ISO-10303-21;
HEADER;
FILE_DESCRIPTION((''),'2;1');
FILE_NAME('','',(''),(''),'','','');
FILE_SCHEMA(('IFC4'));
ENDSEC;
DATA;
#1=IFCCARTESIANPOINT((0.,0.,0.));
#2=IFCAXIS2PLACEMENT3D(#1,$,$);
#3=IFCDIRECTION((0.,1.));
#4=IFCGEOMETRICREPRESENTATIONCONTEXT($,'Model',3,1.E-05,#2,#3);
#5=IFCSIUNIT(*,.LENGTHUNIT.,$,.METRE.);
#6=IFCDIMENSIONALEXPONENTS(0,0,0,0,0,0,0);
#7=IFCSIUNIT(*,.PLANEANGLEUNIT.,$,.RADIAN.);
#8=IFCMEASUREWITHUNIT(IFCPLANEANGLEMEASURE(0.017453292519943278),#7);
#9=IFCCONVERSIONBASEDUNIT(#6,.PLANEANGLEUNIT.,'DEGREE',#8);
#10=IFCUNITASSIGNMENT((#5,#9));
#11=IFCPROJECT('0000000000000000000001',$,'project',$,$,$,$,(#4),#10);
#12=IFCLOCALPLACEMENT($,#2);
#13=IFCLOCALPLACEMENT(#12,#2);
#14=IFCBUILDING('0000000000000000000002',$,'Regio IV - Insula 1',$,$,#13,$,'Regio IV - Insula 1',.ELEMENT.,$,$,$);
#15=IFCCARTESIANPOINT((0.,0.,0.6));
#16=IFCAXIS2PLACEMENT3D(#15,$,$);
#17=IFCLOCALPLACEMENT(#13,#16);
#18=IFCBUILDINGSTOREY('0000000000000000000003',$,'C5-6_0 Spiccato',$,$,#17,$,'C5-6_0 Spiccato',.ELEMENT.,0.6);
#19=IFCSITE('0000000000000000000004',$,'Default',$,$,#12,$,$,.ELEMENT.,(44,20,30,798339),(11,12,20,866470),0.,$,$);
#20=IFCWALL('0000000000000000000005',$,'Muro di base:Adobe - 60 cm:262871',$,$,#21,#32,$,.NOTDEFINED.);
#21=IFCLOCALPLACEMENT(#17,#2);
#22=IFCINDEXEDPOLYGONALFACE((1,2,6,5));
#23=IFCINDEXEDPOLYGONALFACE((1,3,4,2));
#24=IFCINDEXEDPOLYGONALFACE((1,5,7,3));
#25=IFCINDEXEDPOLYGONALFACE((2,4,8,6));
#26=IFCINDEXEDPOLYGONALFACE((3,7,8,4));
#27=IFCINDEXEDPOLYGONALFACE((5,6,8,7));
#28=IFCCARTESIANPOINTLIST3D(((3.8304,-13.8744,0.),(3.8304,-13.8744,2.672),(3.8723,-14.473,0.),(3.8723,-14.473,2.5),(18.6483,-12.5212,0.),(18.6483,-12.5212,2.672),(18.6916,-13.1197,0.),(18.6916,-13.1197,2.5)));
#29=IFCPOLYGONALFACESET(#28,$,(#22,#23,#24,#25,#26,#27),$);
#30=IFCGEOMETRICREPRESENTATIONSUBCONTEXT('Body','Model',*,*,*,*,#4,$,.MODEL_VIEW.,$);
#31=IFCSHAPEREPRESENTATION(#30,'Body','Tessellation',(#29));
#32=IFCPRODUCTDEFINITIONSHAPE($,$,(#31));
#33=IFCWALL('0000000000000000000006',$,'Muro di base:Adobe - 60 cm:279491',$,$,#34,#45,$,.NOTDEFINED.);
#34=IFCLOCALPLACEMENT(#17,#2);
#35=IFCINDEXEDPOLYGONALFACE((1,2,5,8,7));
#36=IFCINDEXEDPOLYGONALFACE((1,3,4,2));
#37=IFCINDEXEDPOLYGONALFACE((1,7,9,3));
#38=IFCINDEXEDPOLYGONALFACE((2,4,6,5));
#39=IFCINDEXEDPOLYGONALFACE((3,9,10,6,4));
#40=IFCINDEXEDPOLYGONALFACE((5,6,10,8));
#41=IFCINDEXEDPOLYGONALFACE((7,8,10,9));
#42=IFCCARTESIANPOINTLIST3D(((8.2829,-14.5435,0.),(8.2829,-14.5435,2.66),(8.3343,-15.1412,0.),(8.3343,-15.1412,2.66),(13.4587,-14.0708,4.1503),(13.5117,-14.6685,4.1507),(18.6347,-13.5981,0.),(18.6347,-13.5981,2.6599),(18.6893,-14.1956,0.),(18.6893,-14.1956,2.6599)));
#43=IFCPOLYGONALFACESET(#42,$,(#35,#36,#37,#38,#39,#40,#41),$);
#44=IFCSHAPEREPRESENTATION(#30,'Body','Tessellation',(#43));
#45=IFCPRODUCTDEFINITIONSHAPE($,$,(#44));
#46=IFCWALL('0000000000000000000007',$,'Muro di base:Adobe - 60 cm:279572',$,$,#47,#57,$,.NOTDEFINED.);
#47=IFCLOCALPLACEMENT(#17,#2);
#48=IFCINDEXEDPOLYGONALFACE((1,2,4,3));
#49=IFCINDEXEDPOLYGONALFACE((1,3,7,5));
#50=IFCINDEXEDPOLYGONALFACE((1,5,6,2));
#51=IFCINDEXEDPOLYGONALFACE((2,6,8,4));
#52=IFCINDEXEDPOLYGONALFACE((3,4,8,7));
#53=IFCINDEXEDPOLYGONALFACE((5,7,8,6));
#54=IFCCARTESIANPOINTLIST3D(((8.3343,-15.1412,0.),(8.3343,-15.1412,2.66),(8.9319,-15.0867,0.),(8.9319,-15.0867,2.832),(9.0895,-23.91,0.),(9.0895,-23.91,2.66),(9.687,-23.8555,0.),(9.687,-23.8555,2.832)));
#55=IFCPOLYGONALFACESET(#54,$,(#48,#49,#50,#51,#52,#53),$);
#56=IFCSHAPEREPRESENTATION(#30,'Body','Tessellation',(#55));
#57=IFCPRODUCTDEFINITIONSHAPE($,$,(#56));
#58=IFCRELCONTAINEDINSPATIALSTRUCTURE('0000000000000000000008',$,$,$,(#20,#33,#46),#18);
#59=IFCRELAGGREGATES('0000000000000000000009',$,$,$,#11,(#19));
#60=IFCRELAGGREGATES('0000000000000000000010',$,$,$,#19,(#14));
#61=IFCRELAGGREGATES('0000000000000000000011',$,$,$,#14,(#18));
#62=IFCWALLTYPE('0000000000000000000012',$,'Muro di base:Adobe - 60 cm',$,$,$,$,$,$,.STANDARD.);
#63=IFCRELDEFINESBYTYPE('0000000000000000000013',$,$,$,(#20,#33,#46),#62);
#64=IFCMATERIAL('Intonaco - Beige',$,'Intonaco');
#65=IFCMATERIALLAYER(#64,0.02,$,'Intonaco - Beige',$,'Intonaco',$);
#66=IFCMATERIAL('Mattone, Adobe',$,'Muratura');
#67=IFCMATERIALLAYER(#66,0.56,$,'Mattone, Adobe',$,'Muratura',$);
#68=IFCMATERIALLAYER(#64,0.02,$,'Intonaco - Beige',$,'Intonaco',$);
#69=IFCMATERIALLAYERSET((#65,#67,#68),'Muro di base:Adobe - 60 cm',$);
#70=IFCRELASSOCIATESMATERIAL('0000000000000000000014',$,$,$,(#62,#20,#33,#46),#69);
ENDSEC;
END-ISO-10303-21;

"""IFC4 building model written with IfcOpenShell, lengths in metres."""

from ifc_helpers import new_model, entity, si_unit, converted_unit, direction, frame, origin, place, context, subcontext, project, spatial, polyline, outline, extrude, clip, bounded_halfspace, material, layer, layer_set, layer_usage, type_object, element, save


model = new_model("IFC4")

# Units and contexts
model_context = context("Model", 3, precision=1e-05, world=origin(), true_north=direction((0.0, 1.0)))
body_context = subcontext(model_context, "Body", "Model", "MODEL_VIEW")
ifc_project = project(units=[si_unit("LENGTHUNIT", "METRE"), converted_unit("PLANEANGLEUNIT", "DEGREE", entity("IfcPlaneAngleMeasure", 0.017453292519943278), si_unit("PLANEANGLEUNIT", "RADIAN"), dimensions=[0, 0, 0, 0, 0, 0, 0])], contexts=[model_context])

# Site, building, storey
site_placement = place(None, origin())
site = spatial("IfcSite", under=ifc_project, at=site_placement, Name="Default", CompositionType="ELEMENT", RefLatitude=(44, 20, 30, 798339), RefLongitude=(11, 12, 20, 866470), RefElevation=0.0)
building_placement = place(site_placement, origin())
building = spatial("IfcBuilding", under=site, at=building_placement, Name="Regio IV - Insula 1", LongName="Regio IV - Insula 1", CompositionType="ELEMENT")
storey_placement = place(building_placement, frame((0.0, 0.0, 0.6)))
storey = spatial("IfcBuildingStorey", under=building, at=storey_placement, Name="C5-6_0 Spiccato", LongName="C5-6_0 Spiccato", CompositionType="ELEMENT", Elevation=0.6)

# Walls
ifc_material_1 = material(Name="Intonaco - Beige", Category="Intonaco")
ifc_layer_1 = layer(ifc_material_1, 0.02, Name="Intonaco - Beige", Category="Intonaco")
ifc_material_2 = material(Name="Mattone, Adobe", Category="Muratura")
ifc_layer_2 = layer(ifc_material_2, 0.56, Name="Mattone, Adobe", Category="Muratura")
ifc_layer_3 = layer(ifc_material_1, 0.02, Name="Intonaco - Beige", Category="Intonaco")
ifc_layer_set_1 = layer_set([ifc_layer_1, ifc_layer_2, ifc_layer_3], Name="Muro di base:Adobe - 60 cm")
ifc_layer_usage_1 = layer_usage(ifc_layer_set_1, "AXIS2", "NEGATIVE", 0.3)
wall_type_1 = type_object("IfcWallType", Name="Muro di base:Adobe - 60 cm", PredefinedType="STANDARD", material=ifc_layer_set_1)
wall_1_placement = place(storey_placement, frame((3.845, -14.1743, 0.0), z_axis=(0.0, 0.0, 1.0), x_axis=(0.995856, 0.090941, 0.0)))
element("IfcWall", 1, at=wall_1_placement, inside=storey, type_object=wall_type_1, material=ifc_layer_usage_1, Name="Muro di base:Adobe - 60 cm:262871", PredefinedType="NOTDEFINED", context=body_context, shape_type="Clipping", body=[
    clip(extrude(outline(polyline([(14.881, -0.3), (14.8923, 0.3), (14.3922, 0.3), (10.4189, 0.3), (9.9189, 0.3), (0.0128, 0.3), (0.0, -0.3), (14.881, -0.3)])), origin(), (0.0, 0.0, 1.0), 2.672), bounded_halfspace(frame((0.0, -0.3, 2.5), z_axis=(0.0, -0.275637, 0.961262), x_axis=(1.0, 0.0, 0.0)), False, frame((0.0, -0.3, 2.5)), polyline([(0.0, 0.0), (14.881, 0.0), (14.8923, 0.6), (14.3922, 0.6), (10.4189, 0.6), (9.9189, 0.6), (0.0128, 0.6), (0.0, 0.0)]))),
])
ifc_layer_usage_2 = layer_usage(ifc_layer_set_1, "AXIS2", "NEGATIVE", 0.3)
wall_2_placement = place(storey_placement, frame((18.662, -13.8969, 0.0), z_axis=(0.0, 0.0, 1.0), x_axis=(-0.995856, -0.090941, 0.0)))
element("IfcWall", 2, at=wall_2_placement, inside=storey, type_object=wall_type_1, material=ifc_layer_usage_2, Name="Muro di base:Adobe - 60 cm:279491", PredefinedType="NOTDEFINED", context=body_context, shape_type="Clipping", body=[
    clip(clip(extrude(outline(polyline([(10.3949, -0.3), (10.398, 0.3), (9.798, 0.3), (0.6, 0.3), (0.0, 0.3), (0.0, -0.3), (10.3949, -0.3)])), origin(), (0.0, 0.0, 1.0), 4.1507), bounded_halfspace(frame((0.0, -0.3, 2.6599), z_axis=(-0.275637, 0.0, 0.961262), x_axis=(0.0, -1.0, 0.0)), False, frame((0.0, -0.3, 2.6599)), polyline([(0.0, 0.0), (5.1976, 0.0), (5.1991, 0.6), (0.6, 0.6), (0.0, 0.6), (0.0, 0.0)]))), bounded_halfspace(frame((5.1976, -0.3, 4.1503), z_axis=(0.275634, -0.001422, 0.961262), x_axis=(0.00516, 0.999987, 0.0)), False, frame((5.1976, -0.3, 4.1503)), polyline([(0.0, 0.0), (5.1974, 0.0), (5.2005, 0.6), (4.6005, 0.6), (0.0015, 0.6), (0.0, 0.0)]))),
])
ifc_layer_usage_3 = layer_usage(ifc_layer_set_1, "AXIS2", "NEGATIVE", 0.3)
wall_3_placement = place(storey_placement, frame((8.633, -15.1124, 0.0), z_axis=(0.0, 0.0, 1.0), x_axis=(0.085801, -0.996312, 0.0)))
element("IfcWall", 3, at=wall_3_placement, inside=storey, type_object=wall_type_1, material=ifc_layer_usage_3, Name="Muro di base:Adobe - 60 cm:279572", PredefinedType="NOTDEFINED", context=body_context, shape_type="Clipping", body=[
    clip(extrude(outline(polyline([(8.8043, -0.3), (8.8012, 0.3), (8.2012, 0.3), (0.0, 0.3), (0.0031, -0.3), (8.8043, -0.3)])), origin(), (0.0, 0.0, 1.0), 2.832), bounded_halfspace(frame((0.0031, -0.3, 2.66), z_axis=(0.0, -0.275637, 0.961262), x_axis=(1.0, 0.0, 0.0)), False, frame((0.0031, -0.3, 2.66)), polyline([(0.0, 0.0), (8.8012, 0.0), (8.7981, 0.6), (8.1981, 0.6), (-0.0031, 0.6), (0.0, 0.0)]))),
])

save(model, "model.ifc")
